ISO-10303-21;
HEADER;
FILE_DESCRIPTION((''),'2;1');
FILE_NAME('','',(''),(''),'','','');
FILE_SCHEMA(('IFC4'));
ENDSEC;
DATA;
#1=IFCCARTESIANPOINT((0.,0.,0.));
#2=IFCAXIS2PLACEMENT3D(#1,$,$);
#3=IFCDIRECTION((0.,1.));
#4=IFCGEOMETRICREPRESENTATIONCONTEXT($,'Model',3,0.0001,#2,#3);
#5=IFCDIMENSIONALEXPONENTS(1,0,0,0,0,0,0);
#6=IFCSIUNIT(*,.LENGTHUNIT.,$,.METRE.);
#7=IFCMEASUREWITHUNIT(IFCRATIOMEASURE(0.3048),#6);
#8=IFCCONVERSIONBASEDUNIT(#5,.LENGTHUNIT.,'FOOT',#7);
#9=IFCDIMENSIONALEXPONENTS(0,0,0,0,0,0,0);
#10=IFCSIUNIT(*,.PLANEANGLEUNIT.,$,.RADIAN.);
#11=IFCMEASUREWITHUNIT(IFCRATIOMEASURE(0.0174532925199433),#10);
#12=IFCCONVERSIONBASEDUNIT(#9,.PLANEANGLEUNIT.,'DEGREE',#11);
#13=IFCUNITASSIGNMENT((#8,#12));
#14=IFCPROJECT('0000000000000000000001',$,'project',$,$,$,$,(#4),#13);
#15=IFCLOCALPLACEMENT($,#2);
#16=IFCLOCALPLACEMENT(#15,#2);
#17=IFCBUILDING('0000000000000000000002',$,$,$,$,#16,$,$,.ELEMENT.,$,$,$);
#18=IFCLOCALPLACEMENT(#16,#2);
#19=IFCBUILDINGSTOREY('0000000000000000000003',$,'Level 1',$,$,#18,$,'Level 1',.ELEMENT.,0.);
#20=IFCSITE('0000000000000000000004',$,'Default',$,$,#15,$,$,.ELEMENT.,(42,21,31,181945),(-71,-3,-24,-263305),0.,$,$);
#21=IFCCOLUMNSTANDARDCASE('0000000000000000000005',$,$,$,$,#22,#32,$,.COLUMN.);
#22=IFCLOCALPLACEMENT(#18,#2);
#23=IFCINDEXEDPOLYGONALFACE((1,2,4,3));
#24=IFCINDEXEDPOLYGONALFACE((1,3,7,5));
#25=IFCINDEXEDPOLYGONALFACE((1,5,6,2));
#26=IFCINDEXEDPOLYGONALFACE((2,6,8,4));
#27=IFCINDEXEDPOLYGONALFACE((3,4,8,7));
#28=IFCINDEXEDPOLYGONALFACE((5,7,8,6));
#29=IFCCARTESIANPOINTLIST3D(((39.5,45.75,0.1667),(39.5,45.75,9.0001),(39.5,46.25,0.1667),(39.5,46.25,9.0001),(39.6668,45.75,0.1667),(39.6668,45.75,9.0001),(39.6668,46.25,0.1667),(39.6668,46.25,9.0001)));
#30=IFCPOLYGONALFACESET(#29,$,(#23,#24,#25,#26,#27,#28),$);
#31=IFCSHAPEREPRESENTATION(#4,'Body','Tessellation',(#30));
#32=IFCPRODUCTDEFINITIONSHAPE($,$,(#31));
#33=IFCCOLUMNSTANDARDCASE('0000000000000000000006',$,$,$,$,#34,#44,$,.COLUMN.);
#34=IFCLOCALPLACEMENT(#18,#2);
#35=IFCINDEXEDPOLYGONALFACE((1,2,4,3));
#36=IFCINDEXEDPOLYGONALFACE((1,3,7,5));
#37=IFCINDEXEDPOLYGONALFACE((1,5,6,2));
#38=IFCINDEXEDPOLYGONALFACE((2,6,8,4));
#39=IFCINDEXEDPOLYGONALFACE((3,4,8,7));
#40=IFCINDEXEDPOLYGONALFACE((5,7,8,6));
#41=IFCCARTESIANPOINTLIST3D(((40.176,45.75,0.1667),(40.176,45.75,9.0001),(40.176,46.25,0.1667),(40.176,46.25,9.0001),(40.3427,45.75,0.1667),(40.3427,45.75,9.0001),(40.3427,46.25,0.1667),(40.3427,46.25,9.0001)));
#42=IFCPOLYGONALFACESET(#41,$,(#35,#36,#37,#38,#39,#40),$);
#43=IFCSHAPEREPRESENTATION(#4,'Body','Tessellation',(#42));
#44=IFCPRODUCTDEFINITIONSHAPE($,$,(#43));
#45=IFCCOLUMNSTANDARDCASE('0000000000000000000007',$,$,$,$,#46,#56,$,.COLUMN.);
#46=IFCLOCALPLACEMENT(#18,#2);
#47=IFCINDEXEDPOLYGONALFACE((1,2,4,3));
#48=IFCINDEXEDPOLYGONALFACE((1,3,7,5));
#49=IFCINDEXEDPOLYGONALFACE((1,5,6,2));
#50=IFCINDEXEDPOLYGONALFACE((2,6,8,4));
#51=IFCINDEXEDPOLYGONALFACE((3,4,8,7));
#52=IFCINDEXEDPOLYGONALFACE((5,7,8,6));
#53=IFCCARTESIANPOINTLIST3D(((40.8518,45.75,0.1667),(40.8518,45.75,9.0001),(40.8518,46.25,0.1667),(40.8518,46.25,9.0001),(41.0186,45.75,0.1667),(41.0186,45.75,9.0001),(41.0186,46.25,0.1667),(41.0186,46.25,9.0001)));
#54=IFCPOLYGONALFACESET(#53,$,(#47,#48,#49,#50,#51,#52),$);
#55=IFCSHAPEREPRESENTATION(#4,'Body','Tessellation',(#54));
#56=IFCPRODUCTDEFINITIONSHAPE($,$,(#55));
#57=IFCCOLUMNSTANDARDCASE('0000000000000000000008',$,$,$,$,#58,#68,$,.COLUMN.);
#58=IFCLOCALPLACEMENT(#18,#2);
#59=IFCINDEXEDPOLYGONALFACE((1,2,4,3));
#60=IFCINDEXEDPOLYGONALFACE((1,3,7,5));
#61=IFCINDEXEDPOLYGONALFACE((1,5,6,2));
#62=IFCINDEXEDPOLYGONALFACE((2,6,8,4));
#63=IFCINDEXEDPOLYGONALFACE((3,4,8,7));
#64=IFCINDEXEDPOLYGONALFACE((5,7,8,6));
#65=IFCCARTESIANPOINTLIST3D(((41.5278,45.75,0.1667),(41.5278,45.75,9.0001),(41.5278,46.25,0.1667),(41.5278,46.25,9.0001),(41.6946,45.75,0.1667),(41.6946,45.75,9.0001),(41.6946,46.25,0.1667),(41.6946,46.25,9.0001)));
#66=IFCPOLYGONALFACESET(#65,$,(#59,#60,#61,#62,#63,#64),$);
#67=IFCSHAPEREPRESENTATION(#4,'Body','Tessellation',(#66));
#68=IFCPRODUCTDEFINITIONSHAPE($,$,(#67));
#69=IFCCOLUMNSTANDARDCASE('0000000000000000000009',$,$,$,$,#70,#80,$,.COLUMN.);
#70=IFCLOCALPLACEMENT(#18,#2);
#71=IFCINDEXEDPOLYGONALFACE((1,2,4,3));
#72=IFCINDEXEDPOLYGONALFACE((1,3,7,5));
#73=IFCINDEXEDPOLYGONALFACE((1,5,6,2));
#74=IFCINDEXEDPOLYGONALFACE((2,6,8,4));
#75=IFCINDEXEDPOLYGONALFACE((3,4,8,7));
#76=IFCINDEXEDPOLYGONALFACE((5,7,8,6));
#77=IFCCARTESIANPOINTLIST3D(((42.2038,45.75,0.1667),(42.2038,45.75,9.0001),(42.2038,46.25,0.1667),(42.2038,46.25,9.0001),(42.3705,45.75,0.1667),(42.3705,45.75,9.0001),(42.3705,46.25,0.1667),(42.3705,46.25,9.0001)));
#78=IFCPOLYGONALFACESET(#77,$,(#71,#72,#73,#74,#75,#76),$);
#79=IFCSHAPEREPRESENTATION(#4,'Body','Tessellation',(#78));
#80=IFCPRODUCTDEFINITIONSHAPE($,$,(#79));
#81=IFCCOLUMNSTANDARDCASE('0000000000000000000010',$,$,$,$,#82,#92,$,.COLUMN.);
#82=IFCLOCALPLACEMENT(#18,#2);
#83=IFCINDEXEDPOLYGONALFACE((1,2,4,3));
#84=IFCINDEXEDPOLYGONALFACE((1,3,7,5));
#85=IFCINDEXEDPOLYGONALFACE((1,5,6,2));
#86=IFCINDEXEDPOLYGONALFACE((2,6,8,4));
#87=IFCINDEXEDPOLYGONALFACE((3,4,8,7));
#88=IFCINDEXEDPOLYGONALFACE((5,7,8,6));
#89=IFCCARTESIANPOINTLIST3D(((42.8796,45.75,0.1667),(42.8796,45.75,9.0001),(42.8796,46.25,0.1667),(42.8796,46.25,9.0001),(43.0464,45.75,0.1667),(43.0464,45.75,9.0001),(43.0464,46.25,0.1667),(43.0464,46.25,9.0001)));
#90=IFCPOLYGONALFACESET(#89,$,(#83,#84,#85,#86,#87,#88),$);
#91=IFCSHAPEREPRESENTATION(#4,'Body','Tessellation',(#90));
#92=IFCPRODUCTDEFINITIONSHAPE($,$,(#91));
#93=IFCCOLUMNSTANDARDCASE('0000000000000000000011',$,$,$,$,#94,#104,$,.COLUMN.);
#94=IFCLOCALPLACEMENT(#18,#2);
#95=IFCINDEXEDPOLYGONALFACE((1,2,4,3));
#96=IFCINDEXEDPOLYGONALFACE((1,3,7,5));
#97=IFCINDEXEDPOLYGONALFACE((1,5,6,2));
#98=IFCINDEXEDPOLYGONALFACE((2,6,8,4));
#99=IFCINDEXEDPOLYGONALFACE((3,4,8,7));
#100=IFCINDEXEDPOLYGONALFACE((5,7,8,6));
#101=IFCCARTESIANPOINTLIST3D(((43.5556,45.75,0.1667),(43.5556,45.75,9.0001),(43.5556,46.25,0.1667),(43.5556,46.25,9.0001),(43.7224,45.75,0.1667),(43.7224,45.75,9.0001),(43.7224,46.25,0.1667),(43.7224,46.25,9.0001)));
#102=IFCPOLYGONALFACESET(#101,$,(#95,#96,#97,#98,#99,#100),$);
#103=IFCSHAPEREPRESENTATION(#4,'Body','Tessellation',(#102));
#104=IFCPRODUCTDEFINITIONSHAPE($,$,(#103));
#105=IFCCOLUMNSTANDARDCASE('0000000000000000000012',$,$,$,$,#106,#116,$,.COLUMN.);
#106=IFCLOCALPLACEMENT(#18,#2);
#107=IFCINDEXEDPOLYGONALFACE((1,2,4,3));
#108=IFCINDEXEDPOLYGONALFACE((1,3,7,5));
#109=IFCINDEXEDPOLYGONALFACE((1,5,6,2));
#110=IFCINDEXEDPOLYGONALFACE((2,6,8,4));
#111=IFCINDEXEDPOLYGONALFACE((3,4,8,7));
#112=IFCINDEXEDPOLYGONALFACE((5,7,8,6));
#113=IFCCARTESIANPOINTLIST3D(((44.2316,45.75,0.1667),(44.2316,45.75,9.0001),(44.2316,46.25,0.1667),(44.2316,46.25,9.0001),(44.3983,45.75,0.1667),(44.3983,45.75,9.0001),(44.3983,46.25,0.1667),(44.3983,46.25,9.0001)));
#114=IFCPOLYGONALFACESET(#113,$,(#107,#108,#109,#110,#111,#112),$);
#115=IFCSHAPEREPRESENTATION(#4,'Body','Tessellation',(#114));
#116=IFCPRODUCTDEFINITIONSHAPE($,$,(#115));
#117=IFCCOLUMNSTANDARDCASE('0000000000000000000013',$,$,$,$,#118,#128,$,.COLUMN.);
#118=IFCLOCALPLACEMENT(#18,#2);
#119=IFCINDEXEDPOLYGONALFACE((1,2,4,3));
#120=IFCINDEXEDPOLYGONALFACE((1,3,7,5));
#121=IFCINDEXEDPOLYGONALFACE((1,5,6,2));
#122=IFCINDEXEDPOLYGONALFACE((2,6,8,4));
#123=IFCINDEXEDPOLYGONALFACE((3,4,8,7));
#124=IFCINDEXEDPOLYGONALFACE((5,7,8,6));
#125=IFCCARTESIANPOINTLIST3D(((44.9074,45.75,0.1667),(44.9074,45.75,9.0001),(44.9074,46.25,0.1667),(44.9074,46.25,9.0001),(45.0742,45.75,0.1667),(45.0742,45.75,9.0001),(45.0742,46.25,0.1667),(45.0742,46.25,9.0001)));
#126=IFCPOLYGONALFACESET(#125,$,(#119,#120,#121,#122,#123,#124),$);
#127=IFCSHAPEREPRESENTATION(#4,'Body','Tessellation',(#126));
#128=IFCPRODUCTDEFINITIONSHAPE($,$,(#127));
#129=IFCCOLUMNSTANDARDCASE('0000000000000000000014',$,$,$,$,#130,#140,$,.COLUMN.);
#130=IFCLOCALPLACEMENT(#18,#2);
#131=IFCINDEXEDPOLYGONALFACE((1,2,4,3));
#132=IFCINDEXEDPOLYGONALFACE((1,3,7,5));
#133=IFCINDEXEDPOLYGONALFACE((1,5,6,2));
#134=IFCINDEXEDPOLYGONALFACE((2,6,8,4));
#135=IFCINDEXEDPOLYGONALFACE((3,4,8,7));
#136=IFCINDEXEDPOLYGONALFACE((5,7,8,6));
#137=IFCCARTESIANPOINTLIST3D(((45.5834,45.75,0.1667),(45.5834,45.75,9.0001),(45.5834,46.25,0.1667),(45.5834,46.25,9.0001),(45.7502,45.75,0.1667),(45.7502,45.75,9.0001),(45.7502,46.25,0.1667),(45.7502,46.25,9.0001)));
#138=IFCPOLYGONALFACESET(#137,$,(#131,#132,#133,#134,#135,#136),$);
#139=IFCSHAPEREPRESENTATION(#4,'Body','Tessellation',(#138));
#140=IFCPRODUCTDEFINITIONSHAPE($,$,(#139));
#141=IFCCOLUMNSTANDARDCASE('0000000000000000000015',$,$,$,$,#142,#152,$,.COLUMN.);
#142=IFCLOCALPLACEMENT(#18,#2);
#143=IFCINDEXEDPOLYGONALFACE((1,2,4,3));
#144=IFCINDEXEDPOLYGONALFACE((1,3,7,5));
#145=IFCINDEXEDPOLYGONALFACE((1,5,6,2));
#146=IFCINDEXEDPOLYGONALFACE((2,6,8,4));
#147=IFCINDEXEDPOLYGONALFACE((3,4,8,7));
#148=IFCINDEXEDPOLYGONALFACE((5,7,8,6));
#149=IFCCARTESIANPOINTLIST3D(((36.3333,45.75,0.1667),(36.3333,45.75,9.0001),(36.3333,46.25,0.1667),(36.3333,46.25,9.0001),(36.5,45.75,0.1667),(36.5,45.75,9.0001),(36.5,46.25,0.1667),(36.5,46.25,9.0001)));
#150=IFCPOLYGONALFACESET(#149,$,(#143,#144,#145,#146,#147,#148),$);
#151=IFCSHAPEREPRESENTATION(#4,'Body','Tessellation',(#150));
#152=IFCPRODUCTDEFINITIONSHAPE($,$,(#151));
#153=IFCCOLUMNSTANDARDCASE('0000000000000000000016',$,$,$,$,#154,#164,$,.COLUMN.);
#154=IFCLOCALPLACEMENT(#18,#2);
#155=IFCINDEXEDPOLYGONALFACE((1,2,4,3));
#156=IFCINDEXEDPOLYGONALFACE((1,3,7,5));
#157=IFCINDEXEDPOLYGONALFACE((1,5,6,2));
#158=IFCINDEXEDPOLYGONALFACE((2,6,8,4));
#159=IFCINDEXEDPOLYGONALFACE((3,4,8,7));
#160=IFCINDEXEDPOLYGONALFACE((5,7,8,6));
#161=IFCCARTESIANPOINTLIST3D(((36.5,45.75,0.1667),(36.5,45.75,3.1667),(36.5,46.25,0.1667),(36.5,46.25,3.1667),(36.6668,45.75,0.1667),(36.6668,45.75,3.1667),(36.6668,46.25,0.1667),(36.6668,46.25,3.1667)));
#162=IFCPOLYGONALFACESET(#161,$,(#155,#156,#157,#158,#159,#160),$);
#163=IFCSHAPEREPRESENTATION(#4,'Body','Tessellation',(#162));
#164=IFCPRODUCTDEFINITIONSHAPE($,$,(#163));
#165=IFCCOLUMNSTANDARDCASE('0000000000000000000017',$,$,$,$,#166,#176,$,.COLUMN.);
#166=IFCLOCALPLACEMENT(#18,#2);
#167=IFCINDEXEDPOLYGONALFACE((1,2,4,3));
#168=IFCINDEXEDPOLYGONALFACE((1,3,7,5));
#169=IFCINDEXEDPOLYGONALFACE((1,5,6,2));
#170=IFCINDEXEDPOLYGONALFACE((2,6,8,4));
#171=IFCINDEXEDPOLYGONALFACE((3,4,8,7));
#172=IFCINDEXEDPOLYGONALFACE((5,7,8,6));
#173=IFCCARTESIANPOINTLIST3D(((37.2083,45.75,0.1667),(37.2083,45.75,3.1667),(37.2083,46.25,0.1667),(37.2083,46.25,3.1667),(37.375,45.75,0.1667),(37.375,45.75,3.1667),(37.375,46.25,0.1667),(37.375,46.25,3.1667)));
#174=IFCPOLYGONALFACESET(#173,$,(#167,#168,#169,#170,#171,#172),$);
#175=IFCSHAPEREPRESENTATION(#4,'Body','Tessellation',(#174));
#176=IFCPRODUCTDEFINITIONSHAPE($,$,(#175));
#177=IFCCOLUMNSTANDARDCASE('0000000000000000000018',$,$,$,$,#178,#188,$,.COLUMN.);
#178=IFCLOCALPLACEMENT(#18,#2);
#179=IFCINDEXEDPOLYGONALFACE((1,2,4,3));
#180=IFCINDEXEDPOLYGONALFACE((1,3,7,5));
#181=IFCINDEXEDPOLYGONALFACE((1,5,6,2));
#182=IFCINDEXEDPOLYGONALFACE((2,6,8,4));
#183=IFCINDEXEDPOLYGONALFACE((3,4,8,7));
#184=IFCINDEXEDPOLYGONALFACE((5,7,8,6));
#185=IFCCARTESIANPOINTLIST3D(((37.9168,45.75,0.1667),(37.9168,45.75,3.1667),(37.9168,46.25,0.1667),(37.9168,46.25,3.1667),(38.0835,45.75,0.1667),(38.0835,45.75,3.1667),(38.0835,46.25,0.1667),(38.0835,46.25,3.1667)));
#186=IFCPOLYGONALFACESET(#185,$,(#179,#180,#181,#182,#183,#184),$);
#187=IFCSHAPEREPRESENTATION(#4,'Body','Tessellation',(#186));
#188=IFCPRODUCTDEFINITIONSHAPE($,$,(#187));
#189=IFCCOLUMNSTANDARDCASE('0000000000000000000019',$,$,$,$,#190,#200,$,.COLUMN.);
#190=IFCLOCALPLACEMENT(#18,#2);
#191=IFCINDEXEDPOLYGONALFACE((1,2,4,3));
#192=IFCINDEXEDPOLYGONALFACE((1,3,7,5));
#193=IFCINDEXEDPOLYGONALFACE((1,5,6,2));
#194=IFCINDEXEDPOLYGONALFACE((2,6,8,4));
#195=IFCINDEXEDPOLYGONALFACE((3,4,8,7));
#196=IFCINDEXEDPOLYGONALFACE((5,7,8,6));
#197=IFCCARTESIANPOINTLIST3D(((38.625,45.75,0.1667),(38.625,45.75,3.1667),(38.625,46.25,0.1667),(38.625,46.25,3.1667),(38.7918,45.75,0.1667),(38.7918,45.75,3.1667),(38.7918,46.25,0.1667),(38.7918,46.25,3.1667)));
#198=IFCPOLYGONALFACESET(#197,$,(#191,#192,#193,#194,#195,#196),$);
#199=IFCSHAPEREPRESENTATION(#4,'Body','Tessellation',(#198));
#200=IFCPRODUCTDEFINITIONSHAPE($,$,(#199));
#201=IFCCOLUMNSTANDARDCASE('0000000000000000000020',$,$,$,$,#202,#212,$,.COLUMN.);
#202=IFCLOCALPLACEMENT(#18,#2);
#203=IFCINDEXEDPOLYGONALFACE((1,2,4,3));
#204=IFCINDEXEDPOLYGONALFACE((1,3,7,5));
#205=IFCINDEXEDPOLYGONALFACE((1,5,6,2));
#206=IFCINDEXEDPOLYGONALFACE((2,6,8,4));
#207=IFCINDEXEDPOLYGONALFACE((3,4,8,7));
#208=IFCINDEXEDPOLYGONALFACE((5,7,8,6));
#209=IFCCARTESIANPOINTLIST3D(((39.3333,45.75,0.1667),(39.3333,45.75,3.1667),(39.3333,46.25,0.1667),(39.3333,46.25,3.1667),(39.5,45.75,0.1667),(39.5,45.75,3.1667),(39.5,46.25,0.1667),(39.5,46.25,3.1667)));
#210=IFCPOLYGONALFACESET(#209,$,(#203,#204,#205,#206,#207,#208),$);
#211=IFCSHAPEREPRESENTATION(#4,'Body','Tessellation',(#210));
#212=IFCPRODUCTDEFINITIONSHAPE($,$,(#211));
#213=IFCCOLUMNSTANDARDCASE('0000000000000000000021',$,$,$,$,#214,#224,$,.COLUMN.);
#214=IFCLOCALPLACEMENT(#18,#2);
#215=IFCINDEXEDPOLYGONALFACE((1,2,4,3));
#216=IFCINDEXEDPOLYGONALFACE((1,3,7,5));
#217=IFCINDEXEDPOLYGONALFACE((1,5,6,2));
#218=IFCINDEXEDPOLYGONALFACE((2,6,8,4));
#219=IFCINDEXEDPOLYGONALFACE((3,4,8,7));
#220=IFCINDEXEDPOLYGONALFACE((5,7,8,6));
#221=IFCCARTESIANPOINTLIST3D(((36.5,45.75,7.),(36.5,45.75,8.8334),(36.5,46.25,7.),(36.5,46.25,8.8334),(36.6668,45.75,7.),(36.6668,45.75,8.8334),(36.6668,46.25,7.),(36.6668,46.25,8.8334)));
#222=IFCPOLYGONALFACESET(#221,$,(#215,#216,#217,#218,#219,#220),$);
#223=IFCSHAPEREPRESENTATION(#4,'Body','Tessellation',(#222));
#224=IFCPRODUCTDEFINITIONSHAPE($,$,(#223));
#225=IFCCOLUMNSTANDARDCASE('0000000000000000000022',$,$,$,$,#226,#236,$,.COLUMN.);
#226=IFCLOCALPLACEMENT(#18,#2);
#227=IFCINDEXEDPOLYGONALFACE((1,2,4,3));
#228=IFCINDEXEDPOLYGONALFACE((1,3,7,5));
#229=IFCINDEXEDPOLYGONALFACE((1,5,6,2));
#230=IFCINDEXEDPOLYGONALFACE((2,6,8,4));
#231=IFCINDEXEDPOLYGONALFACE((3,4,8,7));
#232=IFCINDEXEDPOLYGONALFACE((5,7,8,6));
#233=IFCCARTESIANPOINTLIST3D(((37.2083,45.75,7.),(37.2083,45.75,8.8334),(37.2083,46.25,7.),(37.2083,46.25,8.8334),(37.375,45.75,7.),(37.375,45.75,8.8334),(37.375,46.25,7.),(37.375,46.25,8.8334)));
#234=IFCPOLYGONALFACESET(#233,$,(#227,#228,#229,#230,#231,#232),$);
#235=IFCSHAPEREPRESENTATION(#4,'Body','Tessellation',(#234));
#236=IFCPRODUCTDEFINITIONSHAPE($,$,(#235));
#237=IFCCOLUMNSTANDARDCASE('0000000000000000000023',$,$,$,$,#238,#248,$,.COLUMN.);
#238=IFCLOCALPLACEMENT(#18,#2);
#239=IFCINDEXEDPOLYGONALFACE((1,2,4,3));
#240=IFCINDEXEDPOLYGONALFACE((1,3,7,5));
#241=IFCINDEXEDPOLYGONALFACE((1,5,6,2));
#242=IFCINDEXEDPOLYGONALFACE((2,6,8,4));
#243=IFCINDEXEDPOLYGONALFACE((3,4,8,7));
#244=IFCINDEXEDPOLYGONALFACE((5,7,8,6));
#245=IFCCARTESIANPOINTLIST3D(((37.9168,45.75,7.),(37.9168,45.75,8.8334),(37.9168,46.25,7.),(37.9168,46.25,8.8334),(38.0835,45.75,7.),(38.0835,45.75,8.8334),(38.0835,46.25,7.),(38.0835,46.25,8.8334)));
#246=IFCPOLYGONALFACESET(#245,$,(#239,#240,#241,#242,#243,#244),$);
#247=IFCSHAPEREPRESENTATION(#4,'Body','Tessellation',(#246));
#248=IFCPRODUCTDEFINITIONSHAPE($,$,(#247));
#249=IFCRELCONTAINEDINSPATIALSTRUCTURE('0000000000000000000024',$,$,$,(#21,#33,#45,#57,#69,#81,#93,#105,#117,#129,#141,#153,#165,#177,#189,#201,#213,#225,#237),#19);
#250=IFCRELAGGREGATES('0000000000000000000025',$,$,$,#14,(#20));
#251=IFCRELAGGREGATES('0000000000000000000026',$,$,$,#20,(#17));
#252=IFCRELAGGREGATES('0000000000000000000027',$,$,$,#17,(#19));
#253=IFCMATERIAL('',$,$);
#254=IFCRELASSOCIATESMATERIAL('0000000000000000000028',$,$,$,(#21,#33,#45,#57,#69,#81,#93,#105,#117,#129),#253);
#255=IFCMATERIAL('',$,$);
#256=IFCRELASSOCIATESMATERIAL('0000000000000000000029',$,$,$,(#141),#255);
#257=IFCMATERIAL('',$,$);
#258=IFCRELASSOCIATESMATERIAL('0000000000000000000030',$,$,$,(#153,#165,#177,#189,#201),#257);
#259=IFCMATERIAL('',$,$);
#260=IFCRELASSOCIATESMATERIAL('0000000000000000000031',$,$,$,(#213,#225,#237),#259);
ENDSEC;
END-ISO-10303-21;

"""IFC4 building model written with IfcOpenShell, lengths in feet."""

from ifc_helpers import new_model, entity, si_unit, converted_unit, direction, frame, origin, place, context, project, spatial, rectangle, extrude, material, element, save


model = new_model("IFC4")

# Units and contexts
model_context = context("Model", 3, precision=0.0001, world=origin(), true_north=direction((0.0, 1.0)))
ifc_project = project(units=[converted_unit("LENGTHUNIT", "FOOT", entity("IfcRatioMeasure", 0.3048), si_unit("LENGTHUNIT", "METRE"), dimensions=[1, 0, 0, 0, 0, 0, 0]), converted_unit("PLANEANGLEUNIT", "DEGREE", entity("IfcRatioMeasure", 0.0174532925199433), si_unit("PLANEANGLEUNIT", "RADIAN"), dimensions=[0, 0, 0, 0, 0, 0, 0])], contexts=[model_context])

# Site, building, storey
site_placement = place(None, origin())
site = spatial("IfcSite", under=ifc_project, at=site_placement, Name="Default", CompositionType="ELEMENT", RefLatitude=(42, 21, 31, 181945), RefLongitude=(-71, -3, -24, -263305), RefElevation=0.0)
building_placement = place(site_placement, origin())
building = spatial("IfcBuilding", under=site, at=building_placement, CompositionType="ELEMENT")
storey_placement = place(building_placement, origin())
storey = spatial("IfcBuildingStorey", under=building, at=storey_placement, Name="Level 1", LongName="Level 1", CompositionType="ELEMENT", Elevation=0.0)

# Columns
ifc_material_1 = material(Name="")
placement_1 = place(storey_placement, frame((-0.25, 46.0, 0.0)))
for number, where, z_axis, x_axis in (
    (1, (39.8334, 0.0, 0.1667), (0.0, 0.0, 1.0), (1.0, 0.0, 0.0)),
    (2, (40.5093, 0.0, 0.1667), (0.0, 0.0, 1.0), (1.0, 0.0, 0.0)),
    (3, (41.1852, 0.0, 0.1667), (0.0, 0.0, 1.0), (1.0, 0.0, 0.0)),
    (4, (41.8612, 0.0, 0.1667), (0.0, 0.0, 1.0), (1.0, 0.0, 0.0)),
    (5, (42.5371, 0.0, 0.1667), (0.0, 0.0, 1.0), (1.0, 0.0, 0.0)),
    (6, (43.213, 0.0, 0.1667), (0.0, 0.0, 1.0), (1.0, 0.0, 0.0)),
    (7, (43.889, 0.0, 0.1667), (0.0, 0.0, 1.0), (1.0, 0.0, 0.0)),
    (8, (44.5649, 0.0, 0.1667), (0.0, 0.0, 1.0), (1.0, 0.0, 0.0)),
    (9, (45.2408, 0.0, 0.1667), (0.0, 0.0, 1.0), (1.0, 0.0, 0.0)),
    (10, (45.9168, 0.0, 0.1667), (0.0, 0.0, 1.0), (1.0, 0.0, 0.0)),
):
    element("IfcColumnStandardCase", number, at=place(placement_1, frame(where, z_axis=z_axis, x_axis=x_axis)), inside=storey, material=ifc_material_1, PredefinedType="COLUMN", context=model_context, shape_type="SweptSolid", body=[
        extrude(rectangle(XDim=0.1667, YDim=0.5), origin(), (0.0, 0.0, 1.0), 8.8334),
    ])
ifc_material_2 = material(Name="")
column_placement = place(placement_1, frame((36.6667, 0.0, 0.1667), z_axis=(0.0, 0.0, 1.0), x_axis=(1.0, 0.0, 0.0)))
element("IfcColumnStandardCase", 11, at=column_placement, inside=storey, material=ifc_material_2, PredefinedType="COLUMN", context=model_context, shape_type="SweptSolid", body=[
    extrude(rectangle(XDim=0.1667, YDim=0.5), origin(), (0.0, 0.0, 1.0), 8.8334),
])
ifc_material_3 = material(Name="")
for number, where, z_axis, x_axis in (
    (12, (36.8334, 0.0, 0.1667), (0.0, 0.0, 1.0), (1.0, 0.0, 0.0)),
    (13, (37.5417, 0.0, 0.1667), (0.0, 0.0, 1.0), (1.0, 0.0, 0.0)),
    (14, (38.2501, 0.0, 0.1667), (0.0, 0.0, 1.0), (1.0, 0.0, 0.0)),
    (15, (38.9584, 0.0, 0.1667), (0.0, 0.0, 1.0), (1.0, 0.0, 0.0)),
    (16, (39.6667, 0.0, 0.1667), (0.0, 0.0, 1.0), (1.0, 0.0, 0.0)),
):
    element("IfcColumnStandardCase", number, at=place(placement_1, frame(where, z_axis=z_axis, x_axis=x_axis)), inside=storey, material=ifc_material_3, PredefinedType="COLUMN", context=model_context, shape_type="SweptSolid", body=[
        extrude(rectangle(XDim=0.1667, YDim=0.5), origin(), (0.0, 0.0, 1.0), 3.0),
    ])
ifc_material_4 = material(Name="")
for number, where, z_axis, x_axis in (
    (17, (36.8334, 0.0, 7.0), (0.0, 0.0, 1.0), (1.0, 0.0, 0.0)),
    (18, (37.5417, 0.0, 7.0), (0.0, 0.0, 1.0), (1.0, 0.0, 0.0)),
    (19, (38.2501, 0.0, 7.0), (0.0, 0.0, 1.0), (1.0, 0.0, 0.0)),
):
    element("IfcColumnStandardCase", number, at=place(placement_1, frame(where, z_axis=z_axis, x_axis=x_axis)), inside=storey, material=ifc_material_4, PredefinedType="COLUMN", context=model_context, shape_type="SweptSolid", body=[
        extrude(rectangle(XDim=0.1667, YDim=0.5), origin(), (0.0, 0.0, 1.0), 1.8334),
    ])

save(model, "model.ifc")
